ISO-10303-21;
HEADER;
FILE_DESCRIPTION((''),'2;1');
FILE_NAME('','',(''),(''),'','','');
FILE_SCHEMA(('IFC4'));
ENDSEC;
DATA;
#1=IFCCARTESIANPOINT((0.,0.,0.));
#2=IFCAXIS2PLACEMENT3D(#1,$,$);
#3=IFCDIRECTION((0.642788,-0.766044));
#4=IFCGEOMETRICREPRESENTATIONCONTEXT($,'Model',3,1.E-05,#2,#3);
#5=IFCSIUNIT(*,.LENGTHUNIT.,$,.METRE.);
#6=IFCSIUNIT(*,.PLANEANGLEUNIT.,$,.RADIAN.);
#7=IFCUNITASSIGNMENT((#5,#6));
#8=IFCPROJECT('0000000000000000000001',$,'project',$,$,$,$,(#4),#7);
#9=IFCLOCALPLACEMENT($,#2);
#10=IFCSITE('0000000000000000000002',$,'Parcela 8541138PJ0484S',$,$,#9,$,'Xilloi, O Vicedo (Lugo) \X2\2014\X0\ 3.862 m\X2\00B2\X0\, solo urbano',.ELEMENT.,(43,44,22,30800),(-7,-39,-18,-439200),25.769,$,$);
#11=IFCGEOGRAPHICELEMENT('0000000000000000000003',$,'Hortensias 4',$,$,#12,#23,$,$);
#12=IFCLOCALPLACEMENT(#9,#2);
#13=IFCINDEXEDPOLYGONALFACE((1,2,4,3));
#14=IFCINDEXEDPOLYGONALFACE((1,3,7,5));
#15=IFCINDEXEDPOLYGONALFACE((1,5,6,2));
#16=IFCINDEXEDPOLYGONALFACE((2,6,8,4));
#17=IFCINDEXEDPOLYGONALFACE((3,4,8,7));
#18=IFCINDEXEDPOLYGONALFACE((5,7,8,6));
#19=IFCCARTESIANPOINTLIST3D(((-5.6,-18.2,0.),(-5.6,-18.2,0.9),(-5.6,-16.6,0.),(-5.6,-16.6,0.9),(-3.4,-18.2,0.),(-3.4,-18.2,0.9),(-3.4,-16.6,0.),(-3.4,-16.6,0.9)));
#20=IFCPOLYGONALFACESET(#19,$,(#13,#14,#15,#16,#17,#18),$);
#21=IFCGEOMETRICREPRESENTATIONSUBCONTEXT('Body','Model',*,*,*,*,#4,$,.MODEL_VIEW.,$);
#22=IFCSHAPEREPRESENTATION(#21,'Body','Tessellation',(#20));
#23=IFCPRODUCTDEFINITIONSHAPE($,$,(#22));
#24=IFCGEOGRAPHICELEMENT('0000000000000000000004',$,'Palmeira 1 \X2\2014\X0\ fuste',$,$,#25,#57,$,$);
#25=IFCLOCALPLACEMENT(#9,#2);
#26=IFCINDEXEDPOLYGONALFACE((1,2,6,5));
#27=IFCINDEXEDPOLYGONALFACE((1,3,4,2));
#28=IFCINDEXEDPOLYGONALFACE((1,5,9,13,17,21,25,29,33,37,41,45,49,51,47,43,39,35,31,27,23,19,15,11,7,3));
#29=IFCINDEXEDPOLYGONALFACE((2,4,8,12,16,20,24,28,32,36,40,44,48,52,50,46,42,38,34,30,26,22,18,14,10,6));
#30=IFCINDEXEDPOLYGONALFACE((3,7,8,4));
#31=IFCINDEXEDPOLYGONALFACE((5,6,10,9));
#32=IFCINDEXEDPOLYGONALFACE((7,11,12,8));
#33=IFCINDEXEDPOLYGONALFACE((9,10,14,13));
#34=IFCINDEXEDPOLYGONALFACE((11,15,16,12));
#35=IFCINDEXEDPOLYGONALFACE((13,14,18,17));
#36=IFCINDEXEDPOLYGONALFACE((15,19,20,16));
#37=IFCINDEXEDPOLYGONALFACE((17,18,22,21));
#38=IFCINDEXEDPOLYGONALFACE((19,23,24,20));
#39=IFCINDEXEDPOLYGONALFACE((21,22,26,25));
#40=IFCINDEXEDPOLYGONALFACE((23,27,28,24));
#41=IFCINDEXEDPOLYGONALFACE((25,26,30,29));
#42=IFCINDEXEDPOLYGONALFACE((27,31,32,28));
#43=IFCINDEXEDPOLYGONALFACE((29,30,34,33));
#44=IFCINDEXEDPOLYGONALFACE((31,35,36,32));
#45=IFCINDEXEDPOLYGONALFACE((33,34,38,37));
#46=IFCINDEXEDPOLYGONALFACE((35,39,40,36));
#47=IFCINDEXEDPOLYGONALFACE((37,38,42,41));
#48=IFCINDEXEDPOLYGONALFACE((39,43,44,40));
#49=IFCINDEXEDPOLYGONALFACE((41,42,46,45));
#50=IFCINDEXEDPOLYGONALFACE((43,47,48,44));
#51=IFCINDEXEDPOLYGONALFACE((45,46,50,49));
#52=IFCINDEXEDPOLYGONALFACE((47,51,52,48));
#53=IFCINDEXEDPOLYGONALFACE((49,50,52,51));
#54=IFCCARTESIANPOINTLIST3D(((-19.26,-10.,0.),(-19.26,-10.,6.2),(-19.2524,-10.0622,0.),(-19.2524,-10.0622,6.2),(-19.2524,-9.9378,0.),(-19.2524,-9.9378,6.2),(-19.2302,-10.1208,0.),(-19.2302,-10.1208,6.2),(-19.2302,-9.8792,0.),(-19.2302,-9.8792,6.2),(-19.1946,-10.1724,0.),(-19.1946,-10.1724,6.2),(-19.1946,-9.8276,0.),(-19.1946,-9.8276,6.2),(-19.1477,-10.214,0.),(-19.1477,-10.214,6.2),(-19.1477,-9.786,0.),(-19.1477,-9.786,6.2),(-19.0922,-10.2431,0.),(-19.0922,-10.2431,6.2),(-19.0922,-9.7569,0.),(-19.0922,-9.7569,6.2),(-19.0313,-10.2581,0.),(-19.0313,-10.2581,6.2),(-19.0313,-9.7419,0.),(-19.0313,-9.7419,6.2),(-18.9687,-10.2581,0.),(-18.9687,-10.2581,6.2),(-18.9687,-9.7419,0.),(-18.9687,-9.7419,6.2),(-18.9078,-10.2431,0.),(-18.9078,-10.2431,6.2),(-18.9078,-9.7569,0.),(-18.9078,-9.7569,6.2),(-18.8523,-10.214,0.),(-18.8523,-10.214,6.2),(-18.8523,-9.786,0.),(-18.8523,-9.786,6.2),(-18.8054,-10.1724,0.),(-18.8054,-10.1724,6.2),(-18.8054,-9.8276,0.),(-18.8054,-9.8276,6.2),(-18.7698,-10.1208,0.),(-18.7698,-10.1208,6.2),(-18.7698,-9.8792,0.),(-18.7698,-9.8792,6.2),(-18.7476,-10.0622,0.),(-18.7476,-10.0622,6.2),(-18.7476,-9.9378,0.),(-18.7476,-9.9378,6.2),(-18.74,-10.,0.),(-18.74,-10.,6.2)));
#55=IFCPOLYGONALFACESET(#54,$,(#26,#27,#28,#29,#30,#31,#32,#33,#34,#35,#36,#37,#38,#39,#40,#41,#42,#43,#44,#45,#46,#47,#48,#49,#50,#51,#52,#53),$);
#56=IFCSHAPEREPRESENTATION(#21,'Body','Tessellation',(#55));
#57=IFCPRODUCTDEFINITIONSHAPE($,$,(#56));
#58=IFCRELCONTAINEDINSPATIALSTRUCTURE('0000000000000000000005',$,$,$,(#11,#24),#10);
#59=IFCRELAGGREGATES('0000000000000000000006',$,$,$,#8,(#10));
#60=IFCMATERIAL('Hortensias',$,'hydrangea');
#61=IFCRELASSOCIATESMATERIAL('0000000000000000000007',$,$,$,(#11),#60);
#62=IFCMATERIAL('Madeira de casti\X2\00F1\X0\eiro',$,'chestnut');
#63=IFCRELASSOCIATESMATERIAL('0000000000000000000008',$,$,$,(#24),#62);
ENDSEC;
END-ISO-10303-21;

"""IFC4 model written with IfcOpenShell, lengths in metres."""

from ifc_helpers import new_model, si_unit, direction, frame, origin, origin_2d, place, context, subcontext, project, spatial, rectangle, circle, extrude, material, element, save


model = new_model("IFC4")

# Units and contexts
model_context = context("Model", 3, precision=1e-05, world=origin(), true_north=direction((0.642788, -0.766044)))
body_context = subcontext(model_context, "Body", "Model", "MODEL_VIEW")
ifc_project = project(units=[si_unit("LENGTHUNIT", "METRE"), si_unit("PLANEANGLEUNIT", "RADIAN")], contexts=[model_context])

# Site
site_placement = place(None, origin())
site = spatial("IfcSite", under=ifc_project, at=site_placement, Name="Parcela 8541138PJ0484S", LongName="Xilloi, O Vicedo (Lugo) — 3.862 m², solo urbano", CompositionType="ELEMENT", RefLatitude=(43, 44, 22, 30800), RefLongitude=(-7, -39, -18, -439200), RefElevation=25.769)

# Shared definitions
ifc_material_1 = material(Name="Madeira de castiñeiro", Category="chestnut")

# Geographic elements
ifc_material_2 = material(Name="Hortensias", Category="hydrangea")
for number, where, name in (
    (1, (-4.5, -17.4, 0.45), "Hortensias 4"),
):
    element("IfcGeographicElement", number, at=place(site_placement, frame(where)), inside=site, material=ifc_material_2, Name=name, context=body_context, shape_type="SweptSolid", body=[
        extrude(rectangle(XDim=2.2, YDim=1.6, at=origin_2d()), frame((0.0, 0.0, -0.45)), (0.0, 0.0, 1.0), 0.9),
    ])
geographic_element_1_placement = place(site_placement, frame((-19.0, -10.0, 3.1)))
element("IfcGeographicElement", 2, at=geographic_element_1_placement, inside=site, material=ifc_material_1, Name="Palmeira 1 — fuste", context=body_context, shape_type="SweptSolid", body=[
    extrude(circle(Radius=0.26, at=origin_2d()), frame((0.0, 0.0, -3.1)), (0.0, 0.0, 1.0), 6.2),
])

save(model, "model.ifc")
